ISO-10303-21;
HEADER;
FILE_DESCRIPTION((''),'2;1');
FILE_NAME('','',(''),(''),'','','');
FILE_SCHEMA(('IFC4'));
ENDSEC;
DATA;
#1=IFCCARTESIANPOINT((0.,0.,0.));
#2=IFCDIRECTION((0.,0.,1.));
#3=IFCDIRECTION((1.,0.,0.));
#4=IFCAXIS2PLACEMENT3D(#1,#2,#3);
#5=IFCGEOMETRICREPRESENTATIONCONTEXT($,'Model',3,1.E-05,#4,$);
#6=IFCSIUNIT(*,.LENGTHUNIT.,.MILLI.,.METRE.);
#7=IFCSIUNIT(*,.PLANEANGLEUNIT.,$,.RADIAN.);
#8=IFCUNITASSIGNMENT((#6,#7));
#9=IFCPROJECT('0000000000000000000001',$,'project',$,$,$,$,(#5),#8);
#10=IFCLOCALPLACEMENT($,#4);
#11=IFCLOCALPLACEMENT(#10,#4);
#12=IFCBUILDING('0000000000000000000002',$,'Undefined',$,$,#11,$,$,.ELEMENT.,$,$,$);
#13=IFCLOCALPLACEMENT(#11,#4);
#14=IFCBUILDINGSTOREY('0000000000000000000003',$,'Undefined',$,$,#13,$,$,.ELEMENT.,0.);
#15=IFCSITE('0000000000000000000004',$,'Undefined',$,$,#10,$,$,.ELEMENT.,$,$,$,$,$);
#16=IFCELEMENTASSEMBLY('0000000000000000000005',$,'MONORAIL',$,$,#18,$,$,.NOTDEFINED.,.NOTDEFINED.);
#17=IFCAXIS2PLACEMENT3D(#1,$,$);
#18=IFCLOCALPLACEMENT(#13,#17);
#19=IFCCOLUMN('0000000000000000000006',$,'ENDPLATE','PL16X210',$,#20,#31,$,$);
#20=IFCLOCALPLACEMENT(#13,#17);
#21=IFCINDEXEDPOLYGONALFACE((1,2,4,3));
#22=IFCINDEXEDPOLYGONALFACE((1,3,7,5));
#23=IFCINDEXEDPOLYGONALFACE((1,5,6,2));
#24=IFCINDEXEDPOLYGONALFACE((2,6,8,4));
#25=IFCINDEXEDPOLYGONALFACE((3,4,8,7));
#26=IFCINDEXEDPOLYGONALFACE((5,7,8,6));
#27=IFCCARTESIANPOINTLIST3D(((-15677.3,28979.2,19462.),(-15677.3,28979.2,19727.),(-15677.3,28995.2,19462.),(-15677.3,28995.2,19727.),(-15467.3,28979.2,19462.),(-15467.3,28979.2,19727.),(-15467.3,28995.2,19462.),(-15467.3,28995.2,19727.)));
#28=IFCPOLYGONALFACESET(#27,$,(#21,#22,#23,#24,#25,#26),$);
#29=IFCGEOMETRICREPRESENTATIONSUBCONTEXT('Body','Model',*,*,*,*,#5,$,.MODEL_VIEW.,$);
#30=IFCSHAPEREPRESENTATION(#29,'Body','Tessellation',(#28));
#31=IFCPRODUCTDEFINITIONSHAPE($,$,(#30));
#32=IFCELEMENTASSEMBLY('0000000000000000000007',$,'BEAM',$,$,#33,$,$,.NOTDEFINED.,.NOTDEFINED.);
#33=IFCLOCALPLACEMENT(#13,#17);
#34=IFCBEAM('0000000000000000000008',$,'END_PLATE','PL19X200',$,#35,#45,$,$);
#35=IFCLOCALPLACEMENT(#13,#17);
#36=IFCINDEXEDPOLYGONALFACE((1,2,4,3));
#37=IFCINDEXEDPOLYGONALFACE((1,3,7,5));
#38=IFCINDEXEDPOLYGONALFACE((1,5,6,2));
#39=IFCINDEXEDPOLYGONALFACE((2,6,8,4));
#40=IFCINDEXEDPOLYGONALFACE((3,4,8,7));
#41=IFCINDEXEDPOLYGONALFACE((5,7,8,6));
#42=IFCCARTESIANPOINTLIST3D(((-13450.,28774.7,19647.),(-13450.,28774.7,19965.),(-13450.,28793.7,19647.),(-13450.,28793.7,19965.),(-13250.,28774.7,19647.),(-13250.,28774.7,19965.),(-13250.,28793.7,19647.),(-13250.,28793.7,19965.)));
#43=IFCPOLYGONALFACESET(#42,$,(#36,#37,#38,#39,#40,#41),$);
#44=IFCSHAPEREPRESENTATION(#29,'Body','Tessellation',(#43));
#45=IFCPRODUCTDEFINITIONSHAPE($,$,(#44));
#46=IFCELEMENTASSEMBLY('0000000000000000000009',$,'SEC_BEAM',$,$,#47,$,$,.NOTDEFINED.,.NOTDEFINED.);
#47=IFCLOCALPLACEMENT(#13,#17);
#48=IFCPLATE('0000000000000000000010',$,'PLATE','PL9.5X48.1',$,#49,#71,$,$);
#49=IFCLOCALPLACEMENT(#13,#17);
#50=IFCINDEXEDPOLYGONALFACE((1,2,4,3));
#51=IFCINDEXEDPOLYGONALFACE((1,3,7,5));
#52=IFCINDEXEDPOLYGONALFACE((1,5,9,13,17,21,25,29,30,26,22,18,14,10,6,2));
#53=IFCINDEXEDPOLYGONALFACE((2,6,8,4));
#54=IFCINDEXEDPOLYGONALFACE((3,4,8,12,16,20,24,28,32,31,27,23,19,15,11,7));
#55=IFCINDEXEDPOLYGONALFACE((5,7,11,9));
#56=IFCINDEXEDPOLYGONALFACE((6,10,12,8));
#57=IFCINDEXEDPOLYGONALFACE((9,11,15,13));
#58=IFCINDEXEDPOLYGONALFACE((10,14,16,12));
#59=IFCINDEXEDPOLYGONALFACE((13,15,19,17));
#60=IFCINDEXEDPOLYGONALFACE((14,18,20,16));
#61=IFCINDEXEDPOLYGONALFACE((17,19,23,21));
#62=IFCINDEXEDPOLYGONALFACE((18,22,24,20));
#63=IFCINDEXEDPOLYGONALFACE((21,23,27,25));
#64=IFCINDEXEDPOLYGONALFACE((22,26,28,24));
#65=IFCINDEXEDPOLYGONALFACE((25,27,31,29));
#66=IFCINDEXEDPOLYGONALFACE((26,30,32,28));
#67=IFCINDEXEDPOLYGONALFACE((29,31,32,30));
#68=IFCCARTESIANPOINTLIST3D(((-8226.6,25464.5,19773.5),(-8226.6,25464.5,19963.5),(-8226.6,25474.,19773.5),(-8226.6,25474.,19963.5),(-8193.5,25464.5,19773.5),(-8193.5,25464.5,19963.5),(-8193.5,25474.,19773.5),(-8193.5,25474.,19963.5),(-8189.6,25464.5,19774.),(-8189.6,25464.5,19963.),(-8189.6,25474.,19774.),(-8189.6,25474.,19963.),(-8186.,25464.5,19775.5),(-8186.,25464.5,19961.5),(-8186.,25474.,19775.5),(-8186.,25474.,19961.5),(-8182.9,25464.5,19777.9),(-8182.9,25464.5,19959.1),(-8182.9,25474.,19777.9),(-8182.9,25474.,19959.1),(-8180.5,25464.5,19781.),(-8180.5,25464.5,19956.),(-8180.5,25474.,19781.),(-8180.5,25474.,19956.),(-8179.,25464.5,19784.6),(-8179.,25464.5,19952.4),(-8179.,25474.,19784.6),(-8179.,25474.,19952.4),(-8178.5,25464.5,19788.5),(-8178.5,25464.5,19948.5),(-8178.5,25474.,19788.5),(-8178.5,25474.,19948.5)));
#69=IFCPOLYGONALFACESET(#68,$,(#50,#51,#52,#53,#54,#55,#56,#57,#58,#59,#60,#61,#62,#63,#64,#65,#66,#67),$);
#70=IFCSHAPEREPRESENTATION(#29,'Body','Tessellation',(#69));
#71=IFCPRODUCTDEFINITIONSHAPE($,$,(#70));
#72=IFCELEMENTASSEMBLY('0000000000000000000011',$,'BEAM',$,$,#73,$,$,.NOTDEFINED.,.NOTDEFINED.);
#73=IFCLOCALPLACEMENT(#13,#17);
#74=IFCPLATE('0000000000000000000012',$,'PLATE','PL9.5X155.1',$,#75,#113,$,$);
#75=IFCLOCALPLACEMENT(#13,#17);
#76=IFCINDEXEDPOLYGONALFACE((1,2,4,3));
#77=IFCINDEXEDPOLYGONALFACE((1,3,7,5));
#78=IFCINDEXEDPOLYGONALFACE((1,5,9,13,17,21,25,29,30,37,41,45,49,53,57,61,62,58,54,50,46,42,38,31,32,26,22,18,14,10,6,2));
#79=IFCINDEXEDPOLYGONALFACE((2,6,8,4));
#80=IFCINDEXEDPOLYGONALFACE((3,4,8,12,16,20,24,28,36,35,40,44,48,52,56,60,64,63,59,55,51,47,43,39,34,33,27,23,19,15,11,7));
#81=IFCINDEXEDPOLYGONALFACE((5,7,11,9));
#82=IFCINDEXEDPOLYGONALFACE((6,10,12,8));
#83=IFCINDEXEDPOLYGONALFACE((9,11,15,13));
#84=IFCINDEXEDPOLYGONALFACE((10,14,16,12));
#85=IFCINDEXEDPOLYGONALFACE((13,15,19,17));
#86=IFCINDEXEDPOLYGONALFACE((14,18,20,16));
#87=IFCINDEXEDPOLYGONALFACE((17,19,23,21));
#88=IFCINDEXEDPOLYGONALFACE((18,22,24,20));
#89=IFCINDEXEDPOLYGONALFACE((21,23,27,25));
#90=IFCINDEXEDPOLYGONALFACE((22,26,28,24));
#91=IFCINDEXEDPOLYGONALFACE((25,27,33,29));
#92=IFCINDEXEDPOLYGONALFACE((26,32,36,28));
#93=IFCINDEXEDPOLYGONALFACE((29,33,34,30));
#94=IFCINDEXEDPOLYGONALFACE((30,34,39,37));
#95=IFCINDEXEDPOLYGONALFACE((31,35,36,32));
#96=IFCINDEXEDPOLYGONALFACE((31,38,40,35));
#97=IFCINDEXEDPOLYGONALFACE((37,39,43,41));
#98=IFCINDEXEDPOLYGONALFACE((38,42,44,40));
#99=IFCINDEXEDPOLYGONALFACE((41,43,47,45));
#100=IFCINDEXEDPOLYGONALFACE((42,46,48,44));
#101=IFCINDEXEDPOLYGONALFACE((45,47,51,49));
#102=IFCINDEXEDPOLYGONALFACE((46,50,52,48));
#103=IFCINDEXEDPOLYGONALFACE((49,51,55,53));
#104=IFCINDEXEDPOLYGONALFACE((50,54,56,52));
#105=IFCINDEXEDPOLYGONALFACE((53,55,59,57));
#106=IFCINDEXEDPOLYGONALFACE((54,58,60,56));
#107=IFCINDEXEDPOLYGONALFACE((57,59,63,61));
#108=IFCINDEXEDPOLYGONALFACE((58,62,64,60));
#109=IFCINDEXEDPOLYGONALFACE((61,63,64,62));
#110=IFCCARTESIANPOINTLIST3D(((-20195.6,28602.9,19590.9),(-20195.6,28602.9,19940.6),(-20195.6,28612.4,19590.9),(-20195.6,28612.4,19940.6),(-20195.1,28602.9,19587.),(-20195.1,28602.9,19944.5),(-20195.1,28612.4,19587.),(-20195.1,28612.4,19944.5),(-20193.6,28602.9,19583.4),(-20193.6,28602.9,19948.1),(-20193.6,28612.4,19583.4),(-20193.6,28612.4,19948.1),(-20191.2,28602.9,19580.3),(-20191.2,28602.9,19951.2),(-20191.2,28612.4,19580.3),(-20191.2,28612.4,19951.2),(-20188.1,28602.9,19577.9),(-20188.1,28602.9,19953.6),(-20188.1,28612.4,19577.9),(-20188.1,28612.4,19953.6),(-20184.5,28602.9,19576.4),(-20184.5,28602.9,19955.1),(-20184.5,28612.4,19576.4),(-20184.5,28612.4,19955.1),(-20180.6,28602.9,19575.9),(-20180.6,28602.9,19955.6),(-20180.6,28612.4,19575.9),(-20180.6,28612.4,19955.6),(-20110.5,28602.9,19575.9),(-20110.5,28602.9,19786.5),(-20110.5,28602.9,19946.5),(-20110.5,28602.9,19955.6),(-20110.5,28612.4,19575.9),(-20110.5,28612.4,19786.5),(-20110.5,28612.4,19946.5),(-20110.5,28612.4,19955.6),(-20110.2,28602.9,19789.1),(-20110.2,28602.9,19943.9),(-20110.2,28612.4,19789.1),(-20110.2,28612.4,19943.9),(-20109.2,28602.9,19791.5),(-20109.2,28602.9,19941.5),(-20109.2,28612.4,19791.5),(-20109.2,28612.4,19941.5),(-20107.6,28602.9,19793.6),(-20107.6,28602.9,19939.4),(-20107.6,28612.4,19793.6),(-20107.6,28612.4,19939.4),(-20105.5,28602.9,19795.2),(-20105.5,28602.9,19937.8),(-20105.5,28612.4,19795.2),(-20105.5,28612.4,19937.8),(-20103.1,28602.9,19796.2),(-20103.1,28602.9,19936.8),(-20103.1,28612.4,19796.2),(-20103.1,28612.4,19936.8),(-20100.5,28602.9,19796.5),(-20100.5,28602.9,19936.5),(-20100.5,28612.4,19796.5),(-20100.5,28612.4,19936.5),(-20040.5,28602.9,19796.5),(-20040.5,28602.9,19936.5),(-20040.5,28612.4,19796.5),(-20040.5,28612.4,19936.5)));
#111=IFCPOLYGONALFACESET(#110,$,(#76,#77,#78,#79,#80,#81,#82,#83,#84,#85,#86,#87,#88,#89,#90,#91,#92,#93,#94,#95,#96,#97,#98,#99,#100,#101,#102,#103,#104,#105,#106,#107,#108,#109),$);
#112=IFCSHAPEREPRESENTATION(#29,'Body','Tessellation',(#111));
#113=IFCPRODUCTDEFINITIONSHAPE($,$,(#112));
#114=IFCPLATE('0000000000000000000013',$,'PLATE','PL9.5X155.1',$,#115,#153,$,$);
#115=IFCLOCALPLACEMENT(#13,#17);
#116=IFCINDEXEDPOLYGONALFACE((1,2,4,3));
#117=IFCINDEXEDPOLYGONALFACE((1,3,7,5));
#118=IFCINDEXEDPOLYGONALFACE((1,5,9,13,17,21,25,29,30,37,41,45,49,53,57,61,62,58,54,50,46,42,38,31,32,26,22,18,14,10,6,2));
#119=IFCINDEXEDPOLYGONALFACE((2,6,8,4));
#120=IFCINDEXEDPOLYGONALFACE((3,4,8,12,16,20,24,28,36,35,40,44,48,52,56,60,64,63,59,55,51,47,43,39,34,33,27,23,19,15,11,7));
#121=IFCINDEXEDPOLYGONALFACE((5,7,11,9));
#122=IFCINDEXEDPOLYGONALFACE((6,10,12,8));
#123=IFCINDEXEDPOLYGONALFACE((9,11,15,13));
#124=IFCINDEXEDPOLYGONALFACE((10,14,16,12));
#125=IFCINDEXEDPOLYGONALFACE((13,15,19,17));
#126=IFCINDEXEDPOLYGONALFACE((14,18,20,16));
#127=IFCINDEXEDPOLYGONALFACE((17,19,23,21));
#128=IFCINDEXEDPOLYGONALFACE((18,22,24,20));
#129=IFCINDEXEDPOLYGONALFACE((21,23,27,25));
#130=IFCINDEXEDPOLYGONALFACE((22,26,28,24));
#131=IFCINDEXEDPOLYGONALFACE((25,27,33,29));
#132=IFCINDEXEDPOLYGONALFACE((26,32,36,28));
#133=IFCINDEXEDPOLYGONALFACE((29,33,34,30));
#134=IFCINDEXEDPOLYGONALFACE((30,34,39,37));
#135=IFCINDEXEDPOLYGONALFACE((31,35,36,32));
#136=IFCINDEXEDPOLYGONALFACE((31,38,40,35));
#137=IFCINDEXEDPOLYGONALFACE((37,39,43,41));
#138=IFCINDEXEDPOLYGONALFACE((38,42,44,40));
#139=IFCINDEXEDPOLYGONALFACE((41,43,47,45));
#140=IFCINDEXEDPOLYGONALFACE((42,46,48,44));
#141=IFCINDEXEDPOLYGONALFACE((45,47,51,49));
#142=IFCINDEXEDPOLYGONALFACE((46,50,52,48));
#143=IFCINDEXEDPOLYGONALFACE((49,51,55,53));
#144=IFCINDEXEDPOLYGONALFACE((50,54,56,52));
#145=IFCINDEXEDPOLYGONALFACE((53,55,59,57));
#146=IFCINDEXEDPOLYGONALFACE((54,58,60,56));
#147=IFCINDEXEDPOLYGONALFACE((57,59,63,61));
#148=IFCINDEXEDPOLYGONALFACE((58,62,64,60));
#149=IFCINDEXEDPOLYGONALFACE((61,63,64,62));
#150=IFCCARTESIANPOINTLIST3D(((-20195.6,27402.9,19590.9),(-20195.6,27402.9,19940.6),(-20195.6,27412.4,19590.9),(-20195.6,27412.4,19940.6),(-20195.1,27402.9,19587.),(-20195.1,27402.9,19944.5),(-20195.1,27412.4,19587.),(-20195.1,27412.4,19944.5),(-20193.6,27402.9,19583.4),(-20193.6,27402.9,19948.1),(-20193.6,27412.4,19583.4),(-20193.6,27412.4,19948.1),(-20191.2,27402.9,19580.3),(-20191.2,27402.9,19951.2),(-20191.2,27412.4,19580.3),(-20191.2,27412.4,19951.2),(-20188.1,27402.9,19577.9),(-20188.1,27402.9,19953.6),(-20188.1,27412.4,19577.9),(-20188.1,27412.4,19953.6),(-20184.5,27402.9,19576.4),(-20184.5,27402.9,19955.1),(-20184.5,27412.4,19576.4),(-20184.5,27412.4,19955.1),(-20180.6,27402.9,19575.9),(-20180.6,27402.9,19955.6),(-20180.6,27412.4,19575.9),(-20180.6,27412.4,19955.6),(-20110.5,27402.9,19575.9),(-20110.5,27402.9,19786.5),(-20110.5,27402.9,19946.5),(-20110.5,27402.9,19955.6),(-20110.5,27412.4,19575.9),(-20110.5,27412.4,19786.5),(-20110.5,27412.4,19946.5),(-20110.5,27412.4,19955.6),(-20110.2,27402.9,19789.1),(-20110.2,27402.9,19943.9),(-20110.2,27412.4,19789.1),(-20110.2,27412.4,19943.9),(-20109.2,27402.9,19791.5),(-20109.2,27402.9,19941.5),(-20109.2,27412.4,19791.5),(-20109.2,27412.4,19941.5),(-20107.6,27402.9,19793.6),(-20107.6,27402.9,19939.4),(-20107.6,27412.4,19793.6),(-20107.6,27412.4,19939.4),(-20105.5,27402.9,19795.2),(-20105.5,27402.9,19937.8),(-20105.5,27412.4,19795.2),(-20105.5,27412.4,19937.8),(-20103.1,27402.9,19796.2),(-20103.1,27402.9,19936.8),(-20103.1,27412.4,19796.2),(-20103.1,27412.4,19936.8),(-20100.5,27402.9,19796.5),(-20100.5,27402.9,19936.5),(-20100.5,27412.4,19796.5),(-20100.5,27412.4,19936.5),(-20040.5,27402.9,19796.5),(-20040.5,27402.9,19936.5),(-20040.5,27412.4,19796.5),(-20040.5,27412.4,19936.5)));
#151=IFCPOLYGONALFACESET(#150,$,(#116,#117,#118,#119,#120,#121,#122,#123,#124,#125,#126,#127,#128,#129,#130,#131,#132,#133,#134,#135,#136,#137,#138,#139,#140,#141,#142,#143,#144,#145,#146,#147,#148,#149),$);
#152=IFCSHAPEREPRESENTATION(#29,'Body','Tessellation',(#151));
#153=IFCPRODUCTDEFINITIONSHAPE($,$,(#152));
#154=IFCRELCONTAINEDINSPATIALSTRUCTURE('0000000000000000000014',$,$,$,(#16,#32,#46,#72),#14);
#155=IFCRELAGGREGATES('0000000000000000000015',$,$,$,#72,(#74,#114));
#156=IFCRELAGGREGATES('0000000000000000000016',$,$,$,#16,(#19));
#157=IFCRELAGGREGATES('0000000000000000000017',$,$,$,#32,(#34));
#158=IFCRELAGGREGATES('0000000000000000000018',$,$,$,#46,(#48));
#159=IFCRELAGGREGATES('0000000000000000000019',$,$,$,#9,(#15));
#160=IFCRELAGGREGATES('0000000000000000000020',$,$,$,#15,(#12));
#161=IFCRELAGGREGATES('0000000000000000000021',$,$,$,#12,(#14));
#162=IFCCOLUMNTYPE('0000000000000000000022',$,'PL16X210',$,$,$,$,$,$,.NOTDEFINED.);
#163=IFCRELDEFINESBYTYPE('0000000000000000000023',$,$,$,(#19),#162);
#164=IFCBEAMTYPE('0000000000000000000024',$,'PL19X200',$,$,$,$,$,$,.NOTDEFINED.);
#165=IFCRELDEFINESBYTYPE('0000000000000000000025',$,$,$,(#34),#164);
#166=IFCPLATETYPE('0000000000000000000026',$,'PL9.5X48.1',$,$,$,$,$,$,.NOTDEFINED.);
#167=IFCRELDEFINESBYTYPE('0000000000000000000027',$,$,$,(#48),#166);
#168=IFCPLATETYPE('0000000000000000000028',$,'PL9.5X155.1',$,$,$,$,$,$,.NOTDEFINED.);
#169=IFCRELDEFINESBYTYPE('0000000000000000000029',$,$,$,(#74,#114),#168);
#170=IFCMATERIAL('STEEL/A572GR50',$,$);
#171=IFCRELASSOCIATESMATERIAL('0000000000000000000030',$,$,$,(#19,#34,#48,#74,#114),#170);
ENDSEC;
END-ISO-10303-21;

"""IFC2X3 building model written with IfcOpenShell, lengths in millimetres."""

from ifc_helpers import new_model, si_unit, frame, frame_2d, origin_with_axes, origin_2d_with_axis, place, context, subcontext, project, spatial, polyline, circle_curve, parameter, trimmed, segment, composite_curve, rectangle, outline, extrude, material, type_object, element, aggregate, save


model = new_model("IFC2X3")

# Units and contexts
model_context = context("Model", 3, precision=1e-05, world=origin_with_axes())
body_context = subcontext(model_context, "Body", "Model", "MODEL_VIEW")
ifc_project = project(units=[si_unit("LENGTHUNIT", "METRE", prefix="MILLI"), si_unit("PLANEANGLEUNIT", "RADIAN")], contexts=[model_context])

# Site, building, storey
site_placement = place(None, origin_with_axes())
site = spatial("IfcSite", under=ifc_project, at=site_placement, Name="Undefined", CompositionType="ELEMENT")
building_placement = place(site_placement, origin_with_axes())
building = spatial("IfcBuilding", under=site, at=building_placement, Name="Undefined", CompositionType="ELEMENT")
storey_placement = place(building_placement, origin_with_axes())
storey = spatial("IfcBuildingStorey", under=building, at=storey_placement, Name="Undefined", CompositionType="ELEMENT", Elevation=0.0)

# Element assembly, column
assembly_1_placement = place(storey_placement, origin_with_axes())
assembly_1 = element("IfcElementAssembly", 1, at=assembly_1_placement, inside=storey, Name="MONORAIL", AssemblyPlace="NOTDEFINED", PredefinedType="NOTDEFINED")
ifc_material_1 = material(Name="STEEL/A572GR50")
column_type = type_object("IfcColumnType", Name="PL16X210", PredefinedType="NOTDEFINED")
column_placement = place(assembly_1_placement, frame((-15572.3, 28987.2, 19462.0), z_axis=(0.0, 0.0, 1.0), x_axis=(-1.0, 0.0, 0.0)))
column = element("IfcColumn", 2, at=column_placement, type_object=column_type, material=ifc_material_1, Name="ENDPLATE", Description="PL16X210", context=body_context, shape_type="SweptSolid", body=[
    extrude(rectangle(XDim=16.0, YDim=210.0, at=origin_2d_with_axis()), frame((0.0, 0.0, 265.0), z_axis=(0.0, 0.0, -1.0), x_axis=(0.0, 1.0, 0.0)), (0.0, 0.0, 1.0), 265.0),
])

# Element assembly, beam
assembly_2_placement = place(storey_placement, origin_with_axes())
assembly_2 = element("IfcElementAssembly", 3, at=assembly_2_placement, inside=storey, Name="BEAM", AssemblyPlace="NOTDEFINED", PredefinedType="NOTDEFINED")
beam_type_1 = type_object("IfcBeamType", Name="PL19X200", PredefinedType="NOTDEFINED")
beam_1_placement = place(assembly_2_placement, frame((-13350.0, 28784.2, 19965.0), z_axis=(-1.0, 0.0, 0.0), x_axis=(0.0, 0.0, -1.0)))
beam_1 = element("IfcBeam", 4, at=beam_1_placement, type_object=beam_type_1, material=ifc_material_1, Name="END_PLATE", Description="PL19X200", context=body_context, shape_type="SweptSolid", body=[
    extrude(rectangle(XDim=19.0, YDim=200.0, at=origin_2d_with_axis()), frame((318.0, 0.0, 0.0), z_axis=(-1.0, 0.0, 0.0), x_axis=(0.0, -1.0, 0.0)), (0.0, 0.0, 1.0), 318.0),
])

# Element assembly, plate
assembly_3_placement = place(storey_placement, origin_with_axes())
assembly_3 = element("IfcElementAssembly", 5, at=assembly_3_placement, inside=storey, Name="SEC_BEAM", AssemblyPlace="NOTDEFINED", PredefinedType="NOTDEFINED")
plate_type_1 = type_object("IfcPlateType", Name="PL9.5X48.1", PredefinedType="NOTDEFINED")
plate_1_placement = place(assembly_3_placement, frame((-8226.6, 25469.3, 19773.5), z_axis=(0.0, -1.0, 0.0), x_axis=(1.0, 0.0, 0.0)))
plate_1 = element("IfcPlate", 6, at=plate_1_placement, type_object=plate_type_1, material=ifc_material_1, Name="PLATE", Description="PL9.5X48.1", context=body_context, shape_type="SweptSolid", body=[
    extrude(outline(composite_curve([segment(polyline([(0.0, 0.0), (33.1, 0.0)]), True, "CONTINUOUS"), segment(trimmed(circle_curve(frame_2d((33.1, 15.0), x_axis=(0.0, -1.0)), 15.0), [parameter(0.0)], [parameter(1.570796)], True, "PARAMETER"), True, "CONTINUOUS"), segment(polyline([(48.1, 15.0), (48.1, 175.0)]), True, "CONTINUOUS"), segment(trimmed(circle_curve(frame_2d((33.1, 175.0), x_axis=(1.0, 0.0)), 15.0), [parameter(0.0)], [parameter(1.570796)], True, "PARAMETER"), True, "CONTINUOUS"), segment(polyline([(33.1, 190.0), (0.0, 190.0), (0.0, 0.0)]), True, "CONTINUOUS")], self_intersect=True)), frame((0.0, 0.0, -4.8), z_axis=(0.0, 0.0, 1.0), x_axis=(1.0, 0.0, 0.0)), (0.0, 0.0, 1.0), 9.5),
])

# Element assembly, plates
assembly_4_placement = place(storey_placement, origin_with_axes())
assembly_4 = element("IfcElementAssembly", 7, at=assembly_4_placement, inside=storey, Name="BEAM", AssemblyPlace="NOTDEFINED", PredefinedType="NOTDEFINED")
plate_type_2 = type_object("IfcPlateType", Name="PL9.5X155.1", PredefinedType="NOTDEFINED")
plate_2_placement = place(assembly_4_placement, frame((-20195.6, 28607.7, 19955.6), z_axis=(0.0, -1.0, 0.0), x_axis=(0.0, 0.0, -1.0)))
plate_2 = element("IfcPlate", 8, at=plate_2_placement, type_object=plate_type_2, material=ifc_material_1, Name="PLATE", Description="PL9.5X155.1", context=body_context, shape_type="SweptSolid", body=[
    extrude(outline(composite_curve([segment(trimmed(circle_curve(frame_2d((15.0, 15.0), x_axis=(-1.0, 0.0)), 15.0), [parameter(0.0)], [parameter(1.570796)], True, "PARAMETER"), True, "CONTINUOUS"), segment(polyline([(15.0, 0.0), (364.7, 0.0)]), True, "CONTINUOUS"), segment(trimmed(circle_curve(frame_2d((364.7, 15.0), x_axis=(0.0, -1.0)), 15.0), [parameter(0.0)], [parameter(1.570796)], True, "PARAMETER"), True, "CONTINUOUS"), segment(polyline([(379.7, 15.0), (379.7, 85.1), (169.1, 85.1)]), True, "CONTINUOUS"), segment(trimmed(circle_curve(frame_2d((169.1, 95.1), x_axis=(0.0, -1.0)), 10.0), [parameter(0.0)], [parameter(4.712389)], False, "PARAMETER"), True, "CONTINUOUS"), segment(polyline([(159.1, 95.1), (159.1, 155.1), (19.1, 155.1), (19.1, 95.1)]), True, "CONTINUOUS"), segment(trimmed(circle_curve(frame_2d((9.1, 95.1), x_axis=(1.0, 0.0)), 10.0), [parameter(0.0)], [parameter(4.712389)], False, "PARAMETER"), True, "CONTINUOUS"), segment(polyline([(9.1, 85.1), (0.0, 85.1), (0.0, 15.0)]), True, "CONTINUOUS")], self_intersect=True)), frame((0.0, 0.0, -4.8), z_axis=(0.0, 0.0, 1.0), x_axis=(1.0, 0.0, 0.0)), (0.0, 0.0, 1.0), 9.5),
])
plate_3_placement = place(assembly_4_placement, frame((-20195.6, 27407.7, 19955.6), z_axis=(0.0, -1.0, 0.0), x_axis=(0.0, 0.0, -1.0)))
plate_3 = element("IfcPlate", 9, at=plate_3_placement, type_object=plate_type_2, material=ifc_material_1, Name="PLATE", Description="PL9.5X155.1", context=body_context, shape_type="SweptSolid", body=[
    extrude(outline(composite_curve([segment(trimmed(circle_curve(frame_2d((15.0, 15.0), x_axis=(-1.0, 0.0)), 15.0), [parameter(0.0)], [parameter(1.570796)], True, "PARAMETER"), True, "CONTINUOUS"), segment(polyline([(15.0, 0.0), (364.7, 0.0)]), True, "CONTINUOUS"), segment(trimmed(circle_curve(frame_2d((364.7, 15.0), x_axis=(0.0, -1.0)), 15.0), [parameter(0.0)], [parameter(1.570796)], True, "PARAMETER"), True, "CONTINUOUS"), segment(polyline([(379.7, 15.0), (379.7, 85.1), (169.1, 85.1)]), True, "CONTINUOUS"), segment(trimmed(circle_curve(frame_2d((169.1, 95.1), x_axis=(0.0, -1.0)), 10.0), [parameter(0.0)], [parameter(4.712389)], False, "PARAMETER"), True, "CONTINUOUS"), segment(polyline([(159.1, 95.1), (159.1, 155.1), (19.1, 155.1), (19.1, 95.1)]), True, "CONTINUOUS"), segment(trimmed(circle_curve(frame_2d((9.1, 95.1), x_axis=(1.0, 0.0)), 10.0), [parameter(0.0)], [parameter(4.712389)], False, "PARAMETER"), True, "CONTINUOUS"), segment(polyline([(9.1, 85.1), (0.0, 85.1), (0.0, 15.0)]), True, "CONTINUOUS")], self_intersect=True)), frame((0.0, 0.0, -4.8), z_axis=(0.0, 0.0, 1.0), x_axis=(1.0, 0.0, 0.0)), (0.0, 0.0, 1.0), 9.5),
])
aggregate(assembly_4, [plate_2, plate_3])

aggregate(assembly_1, [column])

aggregate(assembly_2, [beam_1])

aggregate(assembly_3, [plate_1])

save(model, "model.ifc")
